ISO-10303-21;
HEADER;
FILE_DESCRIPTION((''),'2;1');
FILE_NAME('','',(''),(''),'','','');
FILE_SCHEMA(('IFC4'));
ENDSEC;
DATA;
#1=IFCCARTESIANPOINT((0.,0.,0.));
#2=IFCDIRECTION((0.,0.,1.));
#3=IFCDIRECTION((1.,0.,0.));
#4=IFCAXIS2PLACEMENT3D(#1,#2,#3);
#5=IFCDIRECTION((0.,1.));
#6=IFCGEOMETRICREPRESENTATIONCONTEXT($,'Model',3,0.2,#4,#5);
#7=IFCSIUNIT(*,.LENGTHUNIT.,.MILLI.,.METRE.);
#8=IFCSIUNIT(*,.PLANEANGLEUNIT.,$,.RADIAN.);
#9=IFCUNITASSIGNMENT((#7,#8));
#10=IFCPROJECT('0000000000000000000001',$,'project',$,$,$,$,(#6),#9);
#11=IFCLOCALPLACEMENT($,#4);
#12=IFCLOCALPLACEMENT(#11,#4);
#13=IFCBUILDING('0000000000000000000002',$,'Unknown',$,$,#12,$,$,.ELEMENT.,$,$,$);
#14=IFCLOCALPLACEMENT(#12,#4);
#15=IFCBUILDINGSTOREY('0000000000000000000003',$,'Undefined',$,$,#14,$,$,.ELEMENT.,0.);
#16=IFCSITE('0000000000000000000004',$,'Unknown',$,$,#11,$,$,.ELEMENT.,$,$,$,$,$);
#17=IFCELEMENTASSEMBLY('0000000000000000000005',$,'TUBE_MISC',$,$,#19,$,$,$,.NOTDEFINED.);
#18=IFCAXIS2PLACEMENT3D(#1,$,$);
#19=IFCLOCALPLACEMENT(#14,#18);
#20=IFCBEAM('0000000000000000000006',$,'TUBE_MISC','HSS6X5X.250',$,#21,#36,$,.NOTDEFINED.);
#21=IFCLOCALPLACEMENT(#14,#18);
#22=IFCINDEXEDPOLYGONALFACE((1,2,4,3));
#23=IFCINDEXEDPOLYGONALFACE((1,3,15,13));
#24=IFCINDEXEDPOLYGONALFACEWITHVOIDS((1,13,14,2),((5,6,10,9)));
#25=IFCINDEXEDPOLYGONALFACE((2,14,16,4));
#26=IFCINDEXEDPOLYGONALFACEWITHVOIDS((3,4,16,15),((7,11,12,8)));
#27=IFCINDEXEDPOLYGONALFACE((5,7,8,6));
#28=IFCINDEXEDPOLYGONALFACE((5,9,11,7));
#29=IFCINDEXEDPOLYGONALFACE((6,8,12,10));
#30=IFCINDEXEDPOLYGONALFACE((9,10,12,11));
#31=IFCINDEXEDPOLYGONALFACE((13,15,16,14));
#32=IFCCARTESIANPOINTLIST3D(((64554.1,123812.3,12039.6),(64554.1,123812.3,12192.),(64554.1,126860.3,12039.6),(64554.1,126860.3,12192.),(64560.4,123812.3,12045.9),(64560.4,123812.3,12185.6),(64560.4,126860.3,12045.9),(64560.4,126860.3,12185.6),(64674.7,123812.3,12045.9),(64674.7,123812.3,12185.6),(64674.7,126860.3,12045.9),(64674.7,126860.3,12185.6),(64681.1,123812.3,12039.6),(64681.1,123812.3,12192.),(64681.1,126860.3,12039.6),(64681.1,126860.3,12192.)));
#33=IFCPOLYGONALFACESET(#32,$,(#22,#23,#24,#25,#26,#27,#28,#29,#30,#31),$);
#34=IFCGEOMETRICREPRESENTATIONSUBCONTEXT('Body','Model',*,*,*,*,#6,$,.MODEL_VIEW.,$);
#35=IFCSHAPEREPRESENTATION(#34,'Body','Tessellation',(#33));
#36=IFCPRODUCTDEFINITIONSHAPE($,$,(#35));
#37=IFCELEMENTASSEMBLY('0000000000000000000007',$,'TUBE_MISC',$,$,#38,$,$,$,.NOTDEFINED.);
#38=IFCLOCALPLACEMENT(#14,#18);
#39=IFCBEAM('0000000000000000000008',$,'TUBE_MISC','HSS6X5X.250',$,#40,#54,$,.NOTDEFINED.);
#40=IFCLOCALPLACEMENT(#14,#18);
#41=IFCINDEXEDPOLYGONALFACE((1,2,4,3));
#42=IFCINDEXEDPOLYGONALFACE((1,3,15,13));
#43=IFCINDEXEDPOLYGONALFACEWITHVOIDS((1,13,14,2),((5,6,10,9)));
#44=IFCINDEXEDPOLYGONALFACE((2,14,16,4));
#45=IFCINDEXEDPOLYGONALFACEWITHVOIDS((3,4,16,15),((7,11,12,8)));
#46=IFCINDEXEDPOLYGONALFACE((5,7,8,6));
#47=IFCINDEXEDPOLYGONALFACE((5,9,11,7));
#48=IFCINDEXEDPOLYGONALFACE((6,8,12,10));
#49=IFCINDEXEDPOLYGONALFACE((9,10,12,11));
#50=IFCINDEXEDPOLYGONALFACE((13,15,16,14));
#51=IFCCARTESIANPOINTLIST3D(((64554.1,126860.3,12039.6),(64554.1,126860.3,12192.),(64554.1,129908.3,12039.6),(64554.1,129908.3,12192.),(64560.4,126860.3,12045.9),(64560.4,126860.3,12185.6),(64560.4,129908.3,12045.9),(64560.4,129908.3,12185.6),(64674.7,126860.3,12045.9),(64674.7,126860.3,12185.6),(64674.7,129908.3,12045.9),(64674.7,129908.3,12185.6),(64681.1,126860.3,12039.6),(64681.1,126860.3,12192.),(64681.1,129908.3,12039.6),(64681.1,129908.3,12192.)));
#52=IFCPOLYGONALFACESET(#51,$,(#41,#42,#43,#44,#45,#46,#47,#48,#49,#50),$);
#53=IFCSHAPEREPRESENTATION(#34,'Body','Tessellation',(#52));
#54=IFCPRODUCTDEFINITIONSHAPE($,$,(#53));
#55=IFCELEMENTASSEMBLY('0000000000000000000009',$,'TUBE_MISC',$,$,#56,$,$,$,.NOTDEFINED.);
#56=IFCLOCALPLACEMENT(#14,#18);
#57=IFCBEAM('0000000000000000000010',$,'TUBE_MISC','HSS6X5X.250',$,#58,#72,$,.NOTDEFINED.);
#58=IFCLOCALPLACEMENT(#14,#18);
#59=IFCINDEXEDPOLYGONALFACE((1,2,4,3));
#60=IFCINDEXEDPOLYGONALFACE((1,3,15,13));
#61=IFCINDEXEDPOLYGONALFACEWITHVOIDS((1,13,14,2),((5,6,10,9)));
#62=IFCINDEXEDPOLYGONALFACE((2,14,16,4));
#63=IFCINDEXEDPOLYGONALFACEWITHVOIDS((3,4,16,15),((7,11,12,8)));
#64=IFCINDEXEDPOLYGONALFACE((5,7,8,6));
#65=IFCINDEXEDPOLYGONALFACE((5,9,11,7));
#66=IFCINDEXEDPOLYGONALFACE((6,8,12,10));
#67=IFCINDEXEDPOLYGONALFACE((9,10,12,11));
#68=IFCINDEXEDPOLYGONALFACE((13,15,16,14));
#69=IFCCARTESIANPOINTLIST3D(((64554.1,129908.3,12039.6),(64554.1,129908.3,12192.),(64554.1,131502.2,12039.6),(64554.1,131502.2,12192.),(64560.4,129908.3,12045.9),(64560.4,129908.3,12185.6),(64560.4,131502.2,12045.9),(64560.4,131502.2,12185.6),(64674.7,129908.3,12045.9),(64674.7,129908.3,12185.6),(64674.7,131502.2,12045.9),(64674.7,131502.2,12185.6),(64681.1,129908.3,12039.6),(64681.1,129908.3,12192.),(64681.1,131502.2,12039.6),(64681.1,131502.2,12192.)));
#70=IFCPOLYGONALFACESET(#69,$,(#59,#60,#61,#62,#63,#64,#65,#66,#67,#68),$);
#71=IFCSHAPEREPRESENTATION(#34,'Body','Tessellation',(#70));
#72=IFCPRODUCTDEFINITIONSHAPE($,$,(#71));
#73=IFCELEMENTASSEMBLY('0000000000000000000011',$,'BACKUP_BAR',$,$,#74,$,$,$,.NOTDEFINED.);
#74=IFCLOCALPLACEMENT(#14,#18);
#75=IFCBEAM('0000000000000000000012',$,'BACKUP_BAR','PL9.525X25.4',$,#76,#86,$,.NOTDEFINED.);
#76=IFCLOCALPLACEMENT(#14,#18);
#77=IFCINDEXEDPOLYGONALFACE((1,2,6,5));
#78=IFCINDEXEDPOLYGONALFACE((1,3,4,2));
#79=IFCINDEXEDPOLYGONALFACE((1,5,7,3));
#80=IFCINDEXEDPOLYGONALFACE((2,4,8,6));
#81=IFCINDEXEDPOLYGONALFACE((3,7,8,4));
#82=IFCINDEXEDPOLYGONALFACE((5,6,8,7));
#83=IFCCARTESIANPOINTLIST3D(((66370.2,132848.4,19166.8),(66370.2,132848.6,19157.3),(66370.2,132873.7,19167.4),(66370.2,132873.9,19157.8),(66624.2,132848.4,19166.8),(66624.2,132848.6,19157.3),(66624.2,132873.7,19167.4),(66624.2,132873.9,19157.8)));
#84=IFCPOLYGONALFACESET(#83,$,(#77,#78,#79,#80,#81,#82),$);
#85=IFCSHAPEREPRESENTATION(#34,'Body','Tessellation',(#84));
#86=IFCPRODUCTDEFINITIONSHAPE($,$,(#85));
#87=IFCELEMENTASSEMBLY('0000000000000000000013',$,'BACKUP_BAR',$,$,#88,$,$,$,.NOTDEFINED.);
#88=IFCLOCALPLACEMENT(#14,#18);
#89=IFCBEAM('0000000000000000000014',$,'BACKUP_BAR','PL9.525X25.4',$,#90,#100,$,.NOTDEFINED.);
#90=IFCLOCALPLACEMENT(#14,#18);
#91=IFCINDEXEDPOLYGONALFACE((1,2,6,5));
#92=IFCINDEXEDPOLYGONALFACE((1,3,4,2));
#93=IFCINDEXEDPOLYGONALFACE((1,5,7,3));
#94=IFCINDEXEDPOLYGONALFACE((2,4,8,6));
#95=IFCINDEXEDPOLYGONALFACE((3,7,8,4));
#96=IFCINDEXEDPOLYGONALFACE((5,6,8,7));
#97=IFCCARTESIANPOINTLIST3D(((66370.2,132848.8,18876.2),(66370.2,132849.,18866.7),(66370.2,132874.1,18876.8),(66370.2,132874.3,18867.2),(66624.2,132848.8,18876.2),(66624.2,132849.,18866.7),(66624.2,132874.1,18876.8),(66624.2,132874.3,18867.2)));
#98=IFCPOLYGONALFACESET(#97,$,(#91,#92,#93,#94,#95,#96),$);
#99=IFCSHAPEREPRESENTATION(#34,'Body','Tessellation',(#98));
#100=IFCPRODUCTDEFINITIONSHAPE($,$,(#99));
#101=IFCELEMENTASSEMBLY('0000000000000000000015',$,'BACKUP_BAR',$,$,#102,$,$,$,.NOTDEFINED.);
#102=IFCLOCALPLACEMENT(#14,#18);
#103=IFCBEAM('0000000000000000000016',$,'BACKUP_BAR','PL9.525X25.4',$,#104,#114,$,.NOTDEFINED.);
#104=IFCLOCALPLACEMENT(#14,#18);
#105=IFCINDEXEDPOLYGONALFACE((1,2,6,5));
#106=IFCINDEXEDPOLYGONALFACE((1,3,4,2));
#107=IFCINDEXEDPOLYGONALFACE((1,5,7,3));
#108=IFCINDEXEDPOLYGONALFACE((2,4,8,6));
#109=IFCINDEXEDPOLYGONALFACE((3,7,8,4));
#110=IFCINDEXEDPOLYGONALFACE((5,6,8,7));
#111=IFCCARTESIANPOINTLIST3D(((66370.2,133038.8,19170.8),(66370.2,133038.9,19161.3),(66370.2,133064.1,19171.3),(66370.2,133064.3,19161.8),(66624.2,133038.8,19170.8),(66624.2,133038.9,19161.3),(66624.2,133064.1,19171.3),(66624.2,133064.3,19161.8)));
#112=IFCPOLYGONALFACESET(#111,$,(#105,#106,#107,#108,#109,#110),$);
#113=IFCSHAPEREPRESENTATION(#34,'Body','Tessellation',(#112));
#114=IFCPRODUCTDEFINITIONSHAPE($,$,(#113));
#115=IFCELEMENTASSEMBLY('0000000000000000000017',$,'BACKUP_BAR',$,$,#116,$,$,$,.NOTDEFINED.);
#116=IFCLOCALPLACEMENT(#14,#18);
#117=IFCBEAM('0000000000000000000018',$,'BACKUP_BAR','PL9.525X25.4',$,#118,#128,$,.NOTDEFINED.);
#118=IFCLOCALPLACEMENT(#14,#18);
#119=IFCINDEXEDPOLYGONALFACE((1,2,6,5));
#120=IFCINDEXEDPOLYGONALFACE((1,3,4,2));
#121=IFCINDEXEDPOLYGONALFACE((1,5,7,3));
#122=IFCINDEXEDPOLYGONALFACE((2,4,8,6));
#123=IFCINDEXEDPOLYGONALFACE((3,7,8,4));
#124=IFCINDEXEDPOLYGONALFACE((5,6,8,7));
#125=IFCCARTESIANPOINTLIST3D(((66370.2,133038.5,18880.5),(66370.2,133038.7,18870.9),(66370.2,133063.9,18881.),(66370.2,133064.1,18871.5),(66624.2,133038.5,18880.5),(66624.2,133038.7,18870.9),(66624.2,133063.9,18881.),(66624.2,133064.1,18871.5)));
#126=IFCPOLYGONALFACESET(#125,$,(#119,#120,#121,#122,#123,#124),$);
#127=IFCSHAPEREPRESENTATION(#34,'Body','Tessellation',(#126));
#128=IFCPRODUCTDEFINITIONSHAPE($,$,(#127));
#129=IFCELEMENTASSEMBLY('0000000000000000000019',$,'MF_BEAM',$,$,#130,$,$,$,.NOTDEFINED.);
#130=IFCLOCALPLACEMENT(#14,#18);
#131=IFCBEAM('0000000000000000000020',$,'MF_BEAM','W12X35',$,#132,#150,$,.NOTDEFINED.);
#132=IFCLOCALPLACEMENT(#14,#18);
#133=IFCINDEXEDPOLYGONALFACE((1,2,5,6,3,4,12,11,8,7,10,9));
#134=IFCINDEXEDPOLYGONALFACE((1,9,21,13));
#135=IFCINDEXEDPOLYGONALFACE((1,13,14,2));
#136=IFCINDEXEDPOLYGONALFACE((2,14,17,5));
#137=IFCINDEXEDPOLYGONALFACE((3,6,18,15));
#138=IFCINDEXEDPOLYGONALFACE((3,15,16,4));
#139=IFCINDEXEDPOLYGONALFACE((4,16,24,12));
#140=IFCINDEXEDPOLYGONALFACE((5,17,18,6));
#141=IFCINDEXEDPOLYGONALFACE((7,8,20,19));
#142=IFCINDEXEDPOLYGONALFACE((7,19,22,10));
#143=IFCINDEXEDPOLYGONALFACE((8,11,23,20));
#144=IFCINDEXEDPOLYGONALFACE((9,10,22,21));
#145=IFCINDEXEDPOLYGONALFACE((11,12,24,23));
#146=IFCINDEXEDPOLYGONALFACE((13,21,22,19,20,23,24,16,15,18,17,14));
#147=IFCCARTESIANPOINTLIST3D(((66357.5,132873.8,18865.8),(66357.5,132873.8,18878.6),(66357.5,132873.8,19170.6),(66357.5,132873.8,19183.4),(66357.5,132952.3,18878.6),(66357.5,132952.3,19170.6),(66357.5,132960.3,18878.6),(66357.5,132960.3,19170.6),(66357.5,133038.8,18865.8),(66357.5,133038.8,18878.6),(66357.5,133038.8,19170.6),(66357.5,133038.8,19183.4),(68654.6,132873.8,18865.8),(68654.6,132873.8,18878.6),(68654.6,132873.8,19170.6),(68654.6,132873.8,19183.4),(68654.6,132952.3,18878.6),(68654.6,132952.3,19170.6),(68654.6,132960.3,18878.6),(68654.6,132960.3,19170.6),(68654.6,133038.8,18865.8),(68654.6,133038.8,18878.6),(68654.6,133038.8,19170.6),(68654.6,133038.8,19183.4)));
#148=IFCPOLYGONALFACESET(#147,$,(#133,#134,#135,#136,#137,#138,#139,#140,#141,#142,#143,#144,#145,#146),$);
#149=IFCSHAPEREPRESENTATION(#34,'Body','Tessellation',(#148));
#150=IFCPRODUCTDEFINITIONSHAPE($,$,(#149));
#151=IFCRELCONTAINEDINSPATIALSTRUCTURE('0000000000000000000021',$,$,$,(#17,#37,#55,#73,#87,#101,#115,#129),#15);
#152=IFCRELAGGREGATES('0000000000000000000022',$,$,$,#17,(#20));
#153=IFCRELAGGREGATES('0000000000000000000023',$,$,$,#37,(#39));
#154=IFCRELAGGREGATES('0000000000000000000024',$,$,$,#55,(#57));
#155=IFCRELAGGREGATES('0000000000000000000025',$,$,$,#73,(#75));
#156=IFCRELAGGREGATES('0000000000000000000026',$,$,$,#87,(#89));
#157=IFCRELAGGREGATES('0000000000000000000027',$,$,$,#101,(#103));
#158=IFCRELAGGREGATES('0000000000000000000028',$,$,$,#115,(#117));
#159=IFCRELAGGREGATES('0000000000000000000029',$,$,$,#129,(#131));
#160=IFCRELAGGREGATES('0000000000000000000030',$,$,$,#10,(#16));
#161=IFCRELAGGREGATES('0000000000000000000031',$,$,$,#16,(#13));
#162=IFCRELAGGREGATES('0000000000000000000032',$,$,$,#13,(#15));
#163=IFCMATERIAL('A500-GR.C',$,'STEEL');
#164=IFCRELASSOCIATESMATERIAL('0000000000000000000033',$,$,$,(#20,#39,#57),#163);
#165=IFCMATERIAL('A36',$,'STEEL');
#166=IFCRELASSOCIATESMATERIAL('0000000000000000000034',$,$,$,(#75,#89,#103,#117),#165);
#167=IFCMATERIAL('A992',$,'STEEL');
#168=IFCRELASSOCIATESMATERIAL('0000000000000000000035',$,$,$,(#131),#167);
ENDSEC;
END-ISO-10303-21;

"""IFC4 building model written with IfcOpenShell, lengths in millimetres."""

from ifc_helpers import new_model, si_unit, direction, frame, origin_with_axes, place, context, subcontext, project, spatial, line, indexed_curve, outline, extrude, material, element, aggregate, save


model = new_model("IFC4")

# Units and contexts
model_context = context("Model", 3, precision=0.2, world=origin_with_axes(), true_north=direction((0.0, 1.0)))
body_context = subcontext(model_context, "Body", "Model", "MODEL_VIEW")
ifc_project = project(units=[si_unit("LENGTHUNIT", "METRE", prefix="MILLI"), si_unit("PLANEANGLEUNIT", "RADIAN")], contexts=[model_context])

# Site, building, storey
site_placement = place(None, origin_with_axes())
site = spatial("IfcSite", under=ifc_project, at=site_placement, Name="Unknown", CompositionType="ELEMENT")
building_placement = place(site_placement, origin_with_axes())
building = spatial("IfcBuilding", under=site, at=building_placement, Name="Unknown", CompositionType="ELEMENT")
storey_placement = place(building_placement, origin_with_axes())
storey = spatial("IfcBuildingStorey", under=building, at=storey_placement, Name="Undefined", CompositionType="ELEMENT", Elevation=0.0)

# Element assemblies, beams
assembly_1_placement = place(storey_placement, frame((64617.6, 123812.3, 12115.8), z_axis=(1.0, 0.0, 0.0), x_axis=(0.0, 1.0, 0.0)))
assembly_1 = element("IfcElementAssembly", 1, at=assembly_1_placement, inside=storey, Name="TUBE_MISC", PredefinedType="NOTDEFINED")
ifc_material_1 = material(Name="A500-GR.C", Category="STEEL")
beam_1_placement = place(assembly_1_placement, origin_with_axes())
beam_1 = element("IfcBeam", 2, at=beam_1_placement, material=ifc_material_1, Name="TUBE_MISC", Description="HSS6X5X.250", PredefinedType="NOTDEFINED", context=body_context, shape_type="SolidModel", body=[
    extrude(outline(indexed_curve([(-63.5, -76.2), (63.5, -76.2), (63.5, 76.2), (-63.5, 76.2)], segments=[line(1, 2, 3, 4, 1)]), holes=[indexed_curve([(-57.1, -69.8), (-57.1, 69.8), (57.1, 69.8), (57.1, -69.8)], segments=[line(1, 2, 3, 4, 1)])]), frame((0.0, 0.0, 0.0), z_axis=(-1.0, 0.0, 0.0), x_axis=(0.0, 0.0, 1.0)), (0.0, 0.0, -1.0), 3048.0),
])
aggregate(assembly_1, [beam_1])
assembly_2_placement = place(storey_placement, frame((64617.6, 126860.3, 12115.8), z_axis=(1.0, 0.0, 0.0), x_axis=(0.0, 1.0, 0.0)))
assembly_2 = element("IfcElementAssembly", 3, at=assembly_2_placement, inside=storey, Name="TUBE_MISC", PredefinedType="NOTDEFINED")
beam_2_placement = place(assembly_2_placement, origin_with_axes())
beam_2 = element("IfcBeam", 4, at=beam_2_placement, material=ifc_material_1, Name="TUBE_MISC", Description="HSS6X5X.250", PredefinedType="NOTDEFINED", context=body_context, shape_type="SolidModel", body=[
    extrude(outline(indexed_curve([(-63.5, -76.2), (63.5, -76.2), (63.5, 76.2), (-63.5, 76.2)], segments=[line(1, 2, 3, 4, 1)]), holes=[indexed_curve([(-57.1, -69.8), (-57.1, 69.8), (57.1, 69.8), (57.1, -69.8)], segments=[line(1, 2, 3, 4, 1)])]), frame((0.0, 0.0, 0.0), z_axis=(-1.0, 0.0, 0.0), x_axis=(0.0, 0.0, 1.0)), (0.0, 0.0, -1.0), 3048.0),
])
aggregate(assembly_2, [beam_2])
assembly_3_placement = place(storey_placement, frame((64617.6, 129908.3, 12115.8), z_axis=(1.0, 0.0, 0.0), x_axis=(0.0, 1.0, 0.0)))
assembly_3 = element("IfcElementAssembly", 5, at=assembly_3_placement, inside=storey, Name="TUBE_MISC", PredefinedType="NOTDEFINED")
beam_3_placement = place(assembly_3_placement, origin_with_axes())
beam_3 = element("IfcBeam", 6, at=beam_3_placement, material=ifc_material_1, Name="TUBE_MISC", Description="HSS6X5X.250", PredefinedType="NOTDEFINED", context=body_context, shape_type="SolidModel", body=[
    extrude(outline(indexed_curve([(-63.5, -76.2), (63.5, -76.2), (63.5, 76.2), (-63.5, 76.2)], segments=[line(1, 2, 3, 4, 1)]), holes=[indexed_curve([(-57.1, -69.8), (-57.1, 69.8), (57.1, 69.8), (57.1, -69.8)], segments=[line(1, 2, 3, 4, 1)])]), frame((0.0, 0.0, 0.0), z_axis=(-1.0, 0.0, 0.0), x_axis=(0.0, 0.0, 1.0)), (0.0, 0.0, -1.0), 1593.8),
])
aggregate(assembly_3, [beam_3])
assembly_4_placement = place(storey_placement, frame((66370.2, 132861.2, 19162.3), z_axis=(0.0, -0.020829, 0.999783), x_axis=(1.0, 0.0, 0.0)))
assembly_4 = element("IfcElementAssembly", 7, at=assembly_4_placement, inside=storey, Name="BACKUP_BAR", PredefinedType="NOTDEFINED")
ifc_material_2 = material(Name="A36", Category="STEEL")
beam_4_placement = place(assembly_4_placement, origin_with_axes())
beam_4 = element("IfcBeam", 8, at=beam_4_placement, material=ifc_material_2, Name="BACKUP_BAR", Description="PL9.525X25.4", PredefinedType="NOTDEFINED", context=body_context, shape_type="SolidModel", body=[
    extrude(outline(indexed_curve([(-4.8, -12.7), (4.8, -12.7), (4.8, 12.7), (-4.8, 12.7)], segments=[line(1, 2, 3, 4, 1)])), frame((0.0, 0.0, 0.0), z_axis=(-1.0, 0.0, 0.0), x_axis=(0.0, 0.0, 1.0)), (0.0, 0.0, -1.0), 254.0),
])
aggregate(assembly_4, [beam_4])
assembly_5_placement = place(storey_placement, frame((66370.2, 132861.5, 18871.7), z_axis=(0.0, -0.020829, 0.999783), x_axis=(1.0, 0.0, 0.0)))
assembly_5 = element("IfcElementAssembly", 9, at=assembly_5_placement, inside=storey, Name="BACKUP_BAR", PredefinedType="NOTDEFINED")
beam_5_placement = place(assembly_5_placement, origin_with_axes())
beam_5 = element("IfcBeam", 10, at=beam_5_placement, material=ifc_material_2, Name="BACKUP_BAR", Description="PL9.525X25.4", PredefinedType="NOTDEFINED", context=body_context, shape_type="SolidModel", body=[
    extrude(outline(indexed_curve([(-4.8, -12.7), (4.8, -12.7), (4.8, 12.7), (-4.8, 12.7)], segments=[line(1, 2, 3, 4, 1)])), frame((0.0, 0.0, 0.0), z_axis=(-1.0, 0.0, 0.0), x_axis=(0.0, 0.0, 1.0)), (0.0, 0.0, -1.0), 254.0),
])
aggregate(assembly_5, [beam_5])
assembly_6_placement = place(storey_placement, frame((66624.2, 133051.5, 19166.3), z_axis=(0.0, -0.020847, 0.999783), x_axis=(-1.0, 0.0, 0.0)))
assembly_6 = element("IfcElementAssembly", 11, at=assembly_6_placement, inside=storey, Name="BACKUP_BAR", PredefinedType="NOTDEFINED")
beam_6_placement = place(assembly_6_placement, origin_with_axes())
beam_6 = element("IfcBeam", 12, at=beam_6_placement, material=ifc_material_2, Name="BACKUP_BAR", Description="PL9.525X25.4", PredefinedType="NOTDEFINED", context=body_context, shape_type="SolidModel", body=[
    extrude(outline(indexed_curve([(-4.8, -12.7), (4.8, -12.7), (4.8, 12.7), (-4.8, 12.7)], segments=[line(1, 2, 3, 4, 1)])), frame((0.0, 0.0, 0.0), z_axis=(-1.0, 0.0, 0.0), x_axis=(0.0, 0.0, 1.0)), (0.0, 0.0, -1.0), 254.0),
])
aggregate(assembly_6, [beam_6])
assembly_7_placement = place(storey_placement, frame((66624.2, 133051.3, 18876.0), z_axis=(0.0, -0.020847, 0.999783), x_axis=(-1.0, 0.0, 0.0)))
assembly_7 = element("IfcElementAssembly", 13, at=assembly_7_placement, inside=storey, Name="BACKUP_BAR", PredefinedType="NOTDEFINED")
beam_7_placement = place(assembly_7_placement, origin_with_axes())
beam_7 = element("IfcBeam", 14, at=beam_7_placement, material=ifc_material_2, Name="BACKUP_BAR", Description="PL9.525X25.4", PredefinedType="NOTDEFINED", context=body_context, shape_type="SolidModel", body=[
    extrude(outline(indexed_curve([(-4.8, -12.7), (4.8, -12.7), (4.8, 12.7), (-4.8, 12.7)], segments=[line(1, 2, 3, 4, 1)])), frame((0.0, 0.0, 0.0), z_axis=(-1.0, 0.0, 0.0), x_axis=(0.0, 0.0, 1.0)), (0.0, 0.0, -1.0), 254.0),
])
aggregate(assembly_7, [beam_7])

# Element assembly, beam
assembly_8_placement = place(storey_placement, frame((66357.5, 132956.3, 19024.6), z_axis=(0.0, -1.0, 0.0), x_axis=(1.0, 0.0, 0.0)))
assembly_8 = element("IfcElementAssembly", 15, at=assembly_8_placement, inside=storey, Name="MF_BEAM", PredefinedType="NOTDEFINED")
ifc_material_3 = material(Name="A992", Category="STEEL")
beam_8_placement = place(assembly_8_placement, origin_with_axes())
beam_8 = element("IfcBeam", 16, at=beam_8_placement, material=ifc_material_3, Name="MF_BEAM", Description="W12X35", PredefinedType="NOTDEFINED", context=body_context, shape_type="SolidModel", body=[
    extrude(outline(indexed_curve([(-82.5, -158.8), (82.5, -158.8), (82.5, -146.1), (4.0, -146.1), (4.0, 146.1), (82.5, 146.1), (82.5, 158.8), (-82.5, 158.8), (-82.5, 146.1), (-4.0, 146.1), (-4.0, -146.1), (-82.5, -146.1)], segments=[line(1, 2, 3, 4, 5, 6, 7, 8, 9, 10, 11, 12, 1)])), frame((0.0, 0.0, 0.0), z_axis=(-1.0, 0.0, 0.0), x_axis=(0.0, 0.0, 1.0)), (0.0, 0.0, -1.0), 2297.1),
])
aggregate(assembly_8, [beam_8])

save(model, "model.ifc")
